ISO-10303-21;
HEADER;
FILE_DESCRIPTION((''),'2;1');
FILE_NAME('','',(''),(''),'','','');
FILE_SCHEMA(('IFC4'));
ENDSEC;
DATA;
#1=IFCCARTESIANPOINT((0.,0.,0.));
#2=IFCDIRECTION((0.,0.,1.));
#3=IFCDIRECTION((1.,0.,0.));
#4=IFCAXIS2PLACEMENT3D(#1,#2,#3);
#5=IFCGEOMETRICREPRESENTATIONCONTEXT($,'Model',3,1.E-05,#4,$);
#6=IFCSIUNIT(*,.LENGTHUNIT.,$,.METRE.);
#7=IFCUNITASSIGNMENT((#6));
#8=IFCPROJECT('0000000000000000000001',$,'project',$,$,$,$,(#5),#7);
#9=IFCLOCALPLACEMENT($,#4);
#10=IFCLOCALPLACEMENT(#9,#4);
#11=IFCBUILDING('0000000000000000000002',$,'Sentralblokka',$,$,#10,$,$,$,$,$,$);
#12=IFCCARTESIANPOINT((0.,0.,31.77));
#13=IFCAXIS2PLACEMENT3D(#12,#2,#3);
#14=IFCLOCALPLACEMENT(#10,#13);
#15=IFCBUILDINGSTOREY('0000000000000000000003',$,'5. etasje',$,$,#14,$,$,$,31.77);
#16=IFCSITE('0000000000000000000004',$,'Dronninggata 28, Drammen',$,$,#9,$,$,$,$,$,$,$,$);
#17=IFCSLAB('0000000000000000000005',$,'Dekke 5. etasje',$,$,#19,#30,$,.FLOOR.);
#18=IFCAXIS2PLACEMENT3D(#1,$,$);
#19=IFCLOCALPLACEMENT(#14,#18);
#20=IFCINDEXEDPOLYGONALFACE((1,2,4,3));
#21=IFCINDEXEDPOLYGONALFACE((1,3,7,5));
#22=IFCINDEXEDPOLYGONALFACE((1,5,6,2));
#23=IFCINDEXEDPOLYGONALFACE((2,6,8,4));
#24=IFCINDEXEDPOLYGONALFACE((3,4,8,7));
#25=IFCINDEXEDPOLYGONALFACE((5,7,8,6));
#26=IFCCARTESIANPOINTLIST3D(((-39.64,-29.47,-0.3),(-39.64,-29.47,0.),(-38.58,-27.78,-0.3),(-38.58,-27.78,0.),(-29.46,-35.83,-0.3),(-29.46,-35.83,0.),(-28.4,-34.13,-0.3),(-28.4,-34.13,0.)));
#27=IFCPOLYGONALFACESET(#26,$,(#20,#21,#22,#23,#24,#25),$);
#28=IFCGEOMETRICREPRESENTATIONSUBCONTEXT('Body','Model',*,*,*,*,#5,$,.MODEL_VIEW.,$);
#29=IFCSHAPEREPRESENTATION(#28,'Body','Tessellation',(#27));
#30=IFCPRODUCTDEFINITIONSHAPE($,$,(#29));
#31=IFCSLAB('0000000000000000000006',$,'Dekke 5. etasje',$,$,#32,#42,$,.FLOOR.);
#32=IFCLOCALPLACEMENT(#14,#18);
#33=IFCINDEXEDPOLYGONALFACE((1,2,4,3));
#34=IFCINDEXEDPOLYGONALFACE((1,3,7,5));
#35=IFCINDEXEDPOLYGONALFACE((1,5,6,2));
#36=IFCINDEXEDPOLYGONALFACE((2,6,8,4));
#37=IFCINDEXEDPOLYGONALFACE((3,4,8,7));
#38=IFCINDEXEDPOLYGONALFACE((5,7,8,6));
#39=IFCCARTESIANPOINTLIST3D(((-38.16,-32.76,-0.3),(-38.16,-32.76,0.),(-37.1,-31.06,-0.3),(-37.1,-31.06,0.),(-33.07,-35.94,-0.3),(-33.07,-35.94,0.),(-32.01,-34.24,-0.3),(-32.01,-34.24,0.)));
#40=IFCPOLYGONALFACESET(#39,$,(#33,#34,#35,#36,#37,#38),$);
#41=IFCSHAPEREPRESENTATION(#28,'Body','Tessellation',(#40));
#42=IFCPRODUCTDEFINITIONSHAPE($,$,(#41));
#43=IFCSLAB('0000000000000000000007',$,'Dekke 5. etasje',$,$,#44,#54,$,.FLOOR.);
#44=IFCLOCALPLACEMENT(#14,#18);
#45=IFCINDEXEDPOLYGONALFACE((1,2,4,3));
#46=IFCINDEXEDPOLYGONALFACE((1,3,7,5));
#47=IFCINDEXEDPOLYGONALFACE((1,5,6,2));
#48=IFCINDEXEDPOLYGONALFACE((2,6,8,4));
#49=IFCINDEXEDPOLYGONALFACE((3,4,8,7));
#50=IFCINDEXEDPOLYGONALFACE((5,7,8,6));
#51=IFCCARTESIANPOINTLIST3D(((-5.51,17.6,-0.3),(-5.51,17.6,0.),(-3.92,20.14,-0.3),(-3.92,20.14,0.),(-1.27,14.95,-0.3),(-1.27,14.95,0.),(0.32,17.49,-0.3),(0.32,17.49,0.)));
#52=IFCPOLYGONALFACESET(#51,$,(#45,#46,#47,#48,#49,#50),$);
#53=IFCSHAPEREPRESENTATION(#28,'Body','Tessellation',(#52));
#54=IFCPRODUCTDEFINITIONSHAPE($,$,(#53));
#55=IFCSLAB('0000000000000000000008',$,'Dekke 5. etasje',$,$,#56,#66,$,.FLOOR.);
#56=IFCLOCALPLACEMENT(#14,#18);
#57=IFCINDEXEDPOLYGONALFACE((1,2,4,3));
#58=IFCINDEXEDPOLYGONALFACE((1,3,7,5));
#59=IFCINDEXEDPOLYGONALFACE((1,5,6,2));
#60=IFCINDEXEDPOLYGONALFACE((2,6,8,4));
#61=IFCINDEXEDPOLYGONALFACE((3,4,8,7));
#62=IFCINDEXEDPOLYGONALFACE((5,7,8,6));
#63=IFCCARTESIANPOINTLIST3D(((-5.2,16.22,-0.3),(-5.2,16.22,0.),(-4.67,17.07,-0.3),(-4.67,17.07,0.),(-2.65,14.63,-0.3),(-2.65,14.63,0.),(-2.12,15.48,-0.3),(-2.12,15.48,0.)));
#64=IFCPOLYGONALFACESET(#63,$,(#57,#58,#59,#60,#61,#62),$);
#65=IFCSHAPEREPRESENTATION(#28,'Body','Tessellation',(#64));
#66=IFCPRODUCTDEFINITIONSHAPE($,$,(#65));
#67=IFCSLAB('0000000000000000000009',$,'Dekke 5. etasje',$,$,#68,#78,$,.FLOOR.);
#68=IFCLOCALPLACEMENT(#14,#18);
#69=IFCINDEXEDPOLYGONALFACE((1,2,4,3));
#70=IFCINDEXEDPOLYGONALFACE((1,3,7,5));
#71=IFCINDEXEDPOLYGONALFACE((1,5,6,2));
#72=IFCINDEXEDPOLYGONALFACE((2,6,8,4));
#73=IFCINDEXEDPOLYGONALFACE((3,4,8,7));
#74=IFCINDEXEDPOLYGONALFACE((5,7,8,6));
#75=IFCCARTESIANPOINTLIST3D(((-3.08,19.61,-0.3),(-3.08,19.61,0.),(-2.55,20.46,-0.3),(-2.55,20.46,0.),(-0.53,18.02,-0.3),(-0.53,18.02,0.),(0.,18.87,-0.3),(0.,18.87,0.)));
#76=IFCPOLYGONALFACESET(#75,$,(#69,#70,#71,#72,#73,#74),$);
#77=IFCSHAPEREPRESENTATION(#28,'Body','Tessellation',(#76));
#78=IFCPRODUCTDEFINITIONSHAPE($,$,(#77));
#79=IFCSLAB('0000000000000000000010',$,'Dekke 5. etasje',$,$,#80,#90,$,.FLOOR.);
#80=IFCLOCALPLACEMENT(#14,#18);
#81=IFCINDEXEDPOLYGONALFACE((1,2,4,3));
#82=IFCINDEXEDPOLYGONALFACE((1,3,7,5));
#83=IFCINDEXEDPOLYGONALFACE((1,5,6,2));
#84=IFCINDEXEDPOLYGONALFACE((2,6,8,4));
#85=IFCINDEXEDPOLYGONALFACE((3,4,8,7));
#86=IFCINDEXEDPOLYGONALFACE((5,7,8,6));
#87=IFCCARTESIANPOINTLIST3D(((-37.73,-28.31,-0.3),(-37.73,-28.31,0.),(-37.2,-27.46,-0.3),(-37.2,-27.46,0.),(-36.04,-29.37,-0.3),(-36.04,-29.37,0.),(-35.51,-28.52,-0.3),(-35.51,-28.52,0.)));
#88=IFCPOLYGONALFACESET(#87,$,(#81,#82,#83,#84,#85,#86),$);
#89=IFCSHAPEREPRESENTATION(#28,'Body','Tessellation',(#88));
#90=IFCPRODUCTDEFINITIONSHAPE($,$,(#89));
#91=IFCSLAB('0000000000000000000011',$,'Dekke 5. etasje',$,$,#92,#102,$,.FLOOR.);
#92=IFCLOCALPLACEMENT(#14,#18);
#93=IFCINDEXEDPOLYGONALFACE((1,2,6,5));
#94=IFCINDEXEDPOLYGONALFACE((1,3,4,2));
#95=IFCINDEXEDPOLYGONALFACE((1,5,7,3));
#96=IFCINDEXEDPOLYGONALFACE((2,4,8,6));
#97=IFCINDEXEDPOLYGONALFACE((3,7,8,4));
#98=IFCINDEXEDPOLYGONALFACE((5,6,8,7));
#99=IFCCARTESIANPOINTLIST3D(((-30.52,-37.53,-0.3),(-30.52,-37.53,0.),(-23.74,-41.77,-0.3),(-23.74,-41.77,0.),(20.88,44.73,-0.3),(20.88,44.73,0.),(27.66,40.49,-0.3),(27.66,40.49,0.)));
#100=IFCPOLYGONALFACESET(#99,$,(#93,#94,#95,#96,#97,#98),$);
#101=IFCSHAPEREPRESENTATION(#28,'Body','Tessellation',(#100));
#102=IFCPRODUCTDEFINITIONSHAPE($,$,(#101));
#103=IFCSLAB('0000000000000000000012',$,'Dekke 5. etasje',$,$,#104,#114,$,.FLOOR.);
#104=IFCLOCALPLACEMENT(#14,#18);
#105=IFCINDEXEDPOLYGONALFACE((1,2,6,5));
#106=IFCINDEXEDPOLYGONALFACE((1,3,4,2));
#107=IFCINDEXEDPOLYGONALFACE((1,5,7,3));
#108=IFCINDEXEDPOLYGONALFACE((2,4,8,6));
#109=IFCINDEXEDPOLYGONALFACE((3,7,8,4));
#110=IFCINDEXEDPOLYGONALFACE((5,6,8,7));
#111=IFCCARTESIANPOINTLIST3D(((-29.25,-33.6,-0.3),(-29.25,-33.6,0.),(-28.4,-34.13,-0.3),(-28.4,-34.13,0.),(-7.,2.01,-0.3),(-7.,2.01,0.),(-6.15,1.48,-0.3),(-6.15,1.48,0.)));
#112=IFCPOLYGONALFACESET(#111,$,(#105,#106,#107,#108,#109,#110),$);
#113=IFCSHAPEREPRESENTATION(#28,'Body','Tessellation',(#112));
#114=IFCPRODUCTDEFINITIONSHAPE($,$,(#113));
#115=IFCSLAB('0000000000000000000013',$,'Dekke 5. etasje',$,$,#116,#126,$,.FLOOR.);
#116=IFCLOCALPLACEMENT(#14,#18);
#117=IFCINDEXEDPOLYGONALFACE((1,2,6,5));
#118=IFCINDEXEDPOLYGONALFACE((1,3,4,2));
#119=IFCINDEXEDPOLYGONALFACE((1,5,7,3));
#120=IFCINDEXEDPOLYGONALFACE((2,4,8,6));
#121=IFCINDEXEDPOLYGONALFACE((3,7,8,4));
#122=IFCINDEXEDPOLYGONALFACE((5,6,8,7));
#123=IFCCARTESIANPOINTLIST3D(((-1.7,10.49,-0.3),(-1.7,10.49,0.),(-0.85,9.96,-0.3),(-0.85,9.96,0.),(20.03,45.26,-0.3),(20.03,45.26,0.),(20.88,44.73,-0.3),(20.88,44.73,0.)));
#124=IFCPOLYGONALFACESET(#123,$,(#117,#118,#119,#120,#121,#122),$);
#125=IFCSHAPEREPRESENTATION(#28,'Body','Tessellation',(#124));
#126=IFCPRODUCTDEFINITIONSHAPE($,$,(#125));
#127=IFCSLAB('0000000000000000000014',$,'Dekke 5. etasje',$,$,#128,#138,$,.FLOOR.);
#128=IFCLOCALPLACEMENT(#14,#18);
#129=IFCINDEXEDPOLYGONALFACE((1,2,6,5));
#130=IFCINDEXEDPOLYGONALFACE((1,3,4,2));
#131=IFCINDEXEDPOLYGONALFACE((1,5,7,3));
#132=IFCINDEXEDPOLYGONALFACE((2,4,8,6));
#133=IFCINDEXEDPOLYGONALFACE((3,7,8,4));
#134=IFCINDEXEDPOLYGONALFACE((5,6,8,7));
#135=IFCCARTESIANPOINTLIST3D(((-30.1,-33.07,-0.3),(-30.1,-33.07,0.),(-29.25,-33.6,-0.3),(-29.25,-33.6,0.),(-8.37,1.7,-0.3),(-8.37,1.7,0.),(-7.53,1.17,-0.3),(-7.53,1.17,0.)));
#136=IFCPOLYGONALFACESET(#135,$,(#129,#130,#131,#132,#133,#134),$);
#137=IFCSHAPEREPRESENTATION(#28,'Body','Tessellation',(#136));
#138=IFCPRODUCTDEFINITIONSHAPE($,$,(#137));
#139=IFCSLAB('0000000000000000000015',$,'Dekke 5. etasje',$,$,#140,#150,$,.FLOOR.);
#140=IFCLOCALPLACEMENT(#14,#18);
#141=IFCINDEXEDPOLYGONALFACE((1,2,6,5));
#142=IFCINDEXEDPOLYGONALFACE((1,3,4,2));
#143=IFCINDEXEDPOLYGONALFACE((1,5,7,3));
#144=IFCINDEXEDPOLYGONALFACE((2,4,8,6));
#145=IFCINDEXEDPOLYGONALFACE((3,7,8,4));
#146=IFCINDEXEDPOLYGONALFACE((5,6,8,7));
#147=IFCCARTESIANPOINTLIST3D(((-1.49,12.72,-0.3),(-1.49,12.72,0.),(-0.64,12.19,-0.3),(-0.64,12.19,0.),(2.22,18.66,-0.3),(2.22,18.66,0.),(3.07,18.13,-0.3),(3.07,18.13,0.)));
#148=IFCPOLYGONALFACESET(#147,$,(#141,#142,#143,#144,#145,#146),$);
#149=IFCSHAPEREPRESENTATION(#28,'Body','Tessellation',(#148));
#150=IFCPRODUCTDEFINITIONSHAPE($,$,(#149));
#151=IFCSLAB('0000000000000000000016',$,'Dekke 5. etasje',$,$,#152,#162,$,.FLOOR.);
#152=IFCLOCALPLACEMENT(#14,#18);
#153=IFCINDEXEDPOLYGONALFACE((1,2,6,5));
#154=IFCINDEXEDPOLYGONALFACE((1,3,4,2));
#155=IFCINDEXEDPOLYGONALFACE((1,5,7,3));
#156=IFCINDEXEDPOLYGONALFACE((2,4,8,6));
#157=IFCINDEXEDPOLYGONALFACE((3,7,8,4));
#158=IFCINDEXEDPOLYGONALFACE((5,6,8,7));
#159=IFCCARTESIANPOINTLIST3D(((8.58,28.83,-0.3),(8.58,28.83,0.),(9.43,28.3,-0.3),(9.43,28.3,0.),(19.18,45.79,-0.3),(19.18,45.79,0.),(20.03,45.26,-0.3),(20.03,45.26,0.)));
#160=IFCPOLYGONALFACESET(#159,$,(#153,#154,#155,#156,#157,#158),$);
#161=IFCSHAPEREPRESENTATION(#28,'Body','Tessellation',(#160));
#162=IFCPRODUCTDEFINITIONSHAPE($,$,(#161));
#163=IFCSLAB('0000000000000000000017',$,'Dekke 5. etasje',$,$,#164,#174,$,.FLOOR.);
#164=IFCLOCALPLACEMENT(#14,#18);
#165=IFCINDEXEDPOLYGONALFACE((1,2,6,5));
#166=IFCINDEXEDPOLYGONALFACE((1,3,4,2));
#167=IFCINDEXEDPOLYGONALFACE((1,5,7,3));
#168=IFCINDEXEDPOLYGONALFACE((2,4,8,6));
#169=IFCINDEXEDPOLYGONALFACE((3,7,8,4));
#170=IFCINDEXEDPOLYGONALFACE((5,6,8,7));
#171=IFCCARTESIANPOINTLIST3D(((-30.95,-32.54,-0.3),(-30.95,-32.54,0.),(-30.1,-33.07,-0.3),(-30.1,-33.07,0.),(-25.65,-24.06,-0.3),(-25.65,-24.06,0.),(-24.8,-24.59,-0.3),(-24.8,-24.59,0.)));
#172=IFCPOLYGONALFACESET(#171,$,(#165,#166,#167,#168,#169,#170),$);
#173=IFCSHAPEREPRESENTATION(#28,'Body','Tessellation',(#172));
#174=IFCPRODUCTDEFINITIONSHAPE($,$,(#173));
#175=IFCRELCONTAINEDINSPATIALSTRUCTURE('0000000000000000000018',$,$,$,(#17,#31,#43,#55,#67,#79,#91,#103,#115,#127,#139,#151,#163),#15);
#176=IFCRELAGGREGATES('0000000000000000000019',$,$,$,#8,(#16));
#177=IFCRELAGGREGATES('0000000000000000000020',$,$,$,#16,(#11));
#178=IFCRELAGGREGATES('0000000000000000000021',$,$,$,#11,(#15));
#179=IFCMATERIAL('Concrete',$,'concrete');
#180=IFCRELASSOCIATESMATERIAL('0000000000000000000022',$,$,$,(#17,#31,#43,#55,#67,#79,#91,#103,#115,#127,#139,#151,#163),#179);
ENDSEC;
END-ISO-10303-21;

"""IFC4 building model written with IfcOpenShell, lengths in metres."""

from ifc_helpers import new_model, si_unit, frame, origin_with_axes, place, context, subcontext, project, spatial, polyline, outline, extrude, material, element, save


model = new_model("IFC4")

# Units and contexts
model_context = context("Model", 3, precision=1e-05, world=origin_with_axes())
body_context = subcontext(model_context, "Body", "Model", "MODEL_VIEW")
ifc_project = project(units=[si_unit("LENGTHUNIT", "METRE")], contexts=[model_context])

# Site, building, storey
site_placement = place(None, origin_with_axes())
site = spatial("IfcSite", under=ifc_project, at=site_placement, Name="Dronninggata 28, Drammen")
building_placement = place(site_placement, origin_with_axes())
building = spatial("IfcBuilding", under=site, at=building_placement, Name="Sentralblokka")
storey_placement = place(building_placement, frame((0.0, 0.0, 31.77), z_axis=(0.0, 0.0, 1.0), x_axis=(1.0, 0.0, 0.0)))
storey = spatial("IfcBuildingStorey", under=building, at=storey_placement, Name="5. etasje", Elevation=31.77)

# Slabs
ifc_material = material(Name="Concrete", Category="concrete")
slab_1_placement = place(storey_placement, frame((0.0, 0.0, -31.77), z_axis=(0.0, 0.0, 1.0), x_axis=(1.0, 0.0, 0.0)))
element("IfcSlab", 1, at=slab_1_placement, inside=storey, material=ifc_material, Name="Dekke 5. etasje", PredefinedType="FLOOR", context=body_context, shape_type="SweptSolid", body=[
    extrude(outline(polyline([(-29.46, -35.83), (-28.4, -34.13), (-38.58, -27.78), (-39.64, -29.47), (-29.46, -35.83)])), frame((0.0, 0.0, 31.47)), (0.0, 0.0, 1.0), 0.3),
])
slab_2_placement = place(storey_placement, frame((0.0, 0.0, -31.77), z_axis=(0.0, 0.0, 1.0), x_axis=(1.0, 0.0, 0.0)))
element("IfcSlab", 2, at=slab_2_placement, inside=storey, material=ifc_material, Name="Dekke 5. etasje", PredefinedType="FLOOR", context=body_context, shape_type="SweptSolid", body=[
    extrude(outline(polyline([(-33.07, -35.94), (-32.01, -34.24), (-37.1, -31.06), (-38.16, -32.76), (-33.07, -35.94)])), frame((0.0, 0.0, 31.47)), (0.0, 0.0, 1.0), 0.3),
])
slab_3_placement = place(storey_placement, frame((0.0, 0.0, -31.77), z_axis=(0.0, 0.0, 1.0), x_axis=(1.0, 0.0, 0.0)))
element("IfcSlab", 3, at=slab_3_placement, inside=storey, material=ifc_material, Name="Dekke 5. etasje", PredefinedType="FLOOR", context=body_context, shape_type="SweptSolid", body=[
    extrude(outline(polyline([(-1.27, 14.95), (0.32, 17.49), (-3.92, 20.14), (-5.51, 17.6), (-1.27, 14.95)])), frame((0.0, 0.0, 31.47)), (0.0, 0.0, 1.0), 0.3),
])
slab_4_placement = place(storey_placement, frame((0.0, 0.0, -31.77), z_axis=(0.0, 0.0, 1.0), x_axis=(1.0, 0.0, 0.0)))
element("IfcSlab", 4, at=slab_4_placement, inside=storey, material=ifc_material, Name="Dekke 5. etasje", PredefinedType="FLOOR", context=body_context, shape_type="SweptSolid", body=[
    extrude(outline(polyline([(-2.65, 14.63), (-2.12, 15.48), (-4.67, 17.07), (-5.2, 16.22), (-2.65, 14.63)])), frame((0.0, 0.0, 31.47)), (0.0, 0.0, 1.0), 0.3),
])
slab_5_placement = place(storey_placement, frame((0.0, 0.0, -31.77), z_axis=(0.0, 0.0, 1.0), x_axis=(1.0, 0.0, 0.0)))
element("IfcSlab", 5, at=slab_5_placement, inside=storey, material=ifc_material, Name="Dekke 5. etasje", PredefinedType="FLOOR", context=body_context, shape_type="SweptSolid", body=[
    extrude(outline(polyline([(-0.53, 18.02), (0.0, 18.87), (-2.55, 20.46), (-3.08, 19.61), (-0.53, 18.02)])), frame((0.0, 0.0, 31.47)), (0.0, 0.0, 1.0), 0.3),
])
slab_6_placement = place(storey_placement, frame((0.0, 0.0, -31.77), z_axis=(0.0, 0.0, 1.0), x_axis=(1.0, 0.0, 0.0)))
element("IfcSlab", 6, at=slab_6_placement, inside=storey, material=ifc_material, Name="Dekke 5. etasje", PredefinedType="FLOOR", context=body_context, shape_type="SweptSolid", body=[
    extrude(outline(polyline([(-36.04, -29.37), (-35.51, -28.52), (-37.2, -27.46), (-37.73, -28.31), (-36.04, -29.37)])), frame((0.0, 0.0, 31.47)), (0.0, 0.0, 1.0), 0.3),
])
slab_7_placement = place(storey_placement, frame((0.0, 0.0, -31.77), z_axis=(0.0, 0.0, 1.0), x_axis=(1.0, 0.0, 0.0)))
element("IfcSlab", 7, at=slab_7_placement, inside=storey, material=ifc_material, Name="Dekke 5. etasje", PredefinedType="FLOOR", context=body_context, shape_type="SweptSolid", body=[
    extrude(outline(polyline([(-23.74, -41.77), (27.66, 40.49), (20.88, 44.73), (-30.52, -37.53), (-23.74, -41.77)])), frame((0.0, 0.0, 31.47)), (0.0, 0.0, 1.0), 0.3),
])
slab_8_placement = place(storey_placement, frame((0.0, 0.0, -31.77), z_axis=(0.0, 0.0, 1.0), x_axis=(1.0, 0.0, 0.0)))
element("IfcSlab", 8, at=slab_8_placement, inside=storey, material=ifc_material, Name="Dekke 5. etasje", PredefinedType="FLOOR", context=body_context, shape_type="SweptSolid", body=[
    extrude(outline(polyline([(-28.4, -34.13), (-6.15, 1.48), (-7.0, 2.01), (-29.25, -33.6), (-28.4, -34.13)])), frame((0.0, 0.0, 31.47)), (0.0, 0.0, 1.0), 0.3),
])
slab_9_placement = place(storey_placement, frame((0.0, 0.0, -31.77), z_axis=(0.0, 0.0, 1.0), x_axis=(1.0, 0.0, 0.0)))
element("IfcSlab", 9, at=slab_9_placement, inside=storey, material=ifc_material, Name="Dekke 5. etasje", PredefinedType="FLOOR", context=body_context, shape_type="SweptSolid", body=[
    extrude(outline(polyline([(-0.85, 9.96), (20.88, 44.73), (20.03, 45.26), (-1.7, 10.49), (-0.85, 9.96)])), frame((0.0, 0.0, 31.47)), (0.0, 0.0, 1.0), 0.3),
])
slab_10_placement = place(storey_placement, frame((0.0, 0.0, -31.77), z_axis=(0.0, 0.0, 1.0), x_axis=(1.0, 0.0, 0.0)))
element("IfcSlab", 10, at=slab_10_placement, inside=storey, material=ifc_material, Name="Dekke 5. etasje", PredefinedType="FLOOR", context=body_context, shape_type="SweptSolid", body=[
    extrude(outline(polyline([(-29.25, -33.6), (-7.53, 1.17), (-8.37, 1.7), (-30.1, -33.07), (-29.25, -33.6)])), frame((0.0, 0.0, 31.47)), (0.0, 0.0, 1.0), 0.3),
])
slab_11_placement = place(storey_placement, frame((0.0, 0.0, -31.77), z_axis=(0.0, 0.0, 1.0), x_axis=(1.0, 0.0, 0.0)))
element("IfcSlab", 11, at=slab_11_placement, inside=storey, material=ifc_material, Name="Dekke 5. etasje", PredefinedType="FLOOR", context=body_context, shape_type="SweptSolid", body=[
    extrude(outline(polyline([(-0.64, 12.19), (3.07, 18.13), (2.22, 18.66), (-1.49, 12.72), (-0.64, 12.19)])), frame((0.0, 0.0, 31.47)), (0.0, 0.0, 1.0), 0.3),
])
slab_12_placement = place(storey_placement, frame((0.0, 0.0, -31.77), z_axis=(0.0, 0.0, 1.0), x_axis=(1.0, 0.0, 0.0)))
element("IfcSlab", 12, at=slab_12_placement, inside=storey, material=ifc_material, Name="Dekke 5. etasje", PredefinedType="FLOOR", context=body_context, shape_type="SweptSolid", body=[
    extrude(outline(polyline([(9.43, 28.3), (20.03, 45.26), (19.18, 45.79), (8.58, 28.83), (9.43, 28.3)])), frame((0.0, 0.0, 31.47)), (0.0, 0.0, 1.0), 0.3),
])
slab_13_placement = place(storey_placement, frame((0.0, 0.0, -31.77), z_axis=(0.0, 0.0, 1.0), x_axis=(1.0, 0.0, 0.0)))
element("IfcSlab", 13, at=slab_13_placement, inside=storey, material=ifc_material, Name="Dekke 5. etasje", PredefinedType="FLOOR", context=body_context, shape_type="SweptSolid", body=[
    extrude(outline(polyline([(-30.1, -33.07), (-24.8, -24.59), (-25.65, -24.06), (-30.95, -32.54), (-30.1, -33.07)])), frame((0.0, 0.0, 31.47)), (0.0, 0.0, 1.0), 0.3),
])

save(model, "model.ifc")
